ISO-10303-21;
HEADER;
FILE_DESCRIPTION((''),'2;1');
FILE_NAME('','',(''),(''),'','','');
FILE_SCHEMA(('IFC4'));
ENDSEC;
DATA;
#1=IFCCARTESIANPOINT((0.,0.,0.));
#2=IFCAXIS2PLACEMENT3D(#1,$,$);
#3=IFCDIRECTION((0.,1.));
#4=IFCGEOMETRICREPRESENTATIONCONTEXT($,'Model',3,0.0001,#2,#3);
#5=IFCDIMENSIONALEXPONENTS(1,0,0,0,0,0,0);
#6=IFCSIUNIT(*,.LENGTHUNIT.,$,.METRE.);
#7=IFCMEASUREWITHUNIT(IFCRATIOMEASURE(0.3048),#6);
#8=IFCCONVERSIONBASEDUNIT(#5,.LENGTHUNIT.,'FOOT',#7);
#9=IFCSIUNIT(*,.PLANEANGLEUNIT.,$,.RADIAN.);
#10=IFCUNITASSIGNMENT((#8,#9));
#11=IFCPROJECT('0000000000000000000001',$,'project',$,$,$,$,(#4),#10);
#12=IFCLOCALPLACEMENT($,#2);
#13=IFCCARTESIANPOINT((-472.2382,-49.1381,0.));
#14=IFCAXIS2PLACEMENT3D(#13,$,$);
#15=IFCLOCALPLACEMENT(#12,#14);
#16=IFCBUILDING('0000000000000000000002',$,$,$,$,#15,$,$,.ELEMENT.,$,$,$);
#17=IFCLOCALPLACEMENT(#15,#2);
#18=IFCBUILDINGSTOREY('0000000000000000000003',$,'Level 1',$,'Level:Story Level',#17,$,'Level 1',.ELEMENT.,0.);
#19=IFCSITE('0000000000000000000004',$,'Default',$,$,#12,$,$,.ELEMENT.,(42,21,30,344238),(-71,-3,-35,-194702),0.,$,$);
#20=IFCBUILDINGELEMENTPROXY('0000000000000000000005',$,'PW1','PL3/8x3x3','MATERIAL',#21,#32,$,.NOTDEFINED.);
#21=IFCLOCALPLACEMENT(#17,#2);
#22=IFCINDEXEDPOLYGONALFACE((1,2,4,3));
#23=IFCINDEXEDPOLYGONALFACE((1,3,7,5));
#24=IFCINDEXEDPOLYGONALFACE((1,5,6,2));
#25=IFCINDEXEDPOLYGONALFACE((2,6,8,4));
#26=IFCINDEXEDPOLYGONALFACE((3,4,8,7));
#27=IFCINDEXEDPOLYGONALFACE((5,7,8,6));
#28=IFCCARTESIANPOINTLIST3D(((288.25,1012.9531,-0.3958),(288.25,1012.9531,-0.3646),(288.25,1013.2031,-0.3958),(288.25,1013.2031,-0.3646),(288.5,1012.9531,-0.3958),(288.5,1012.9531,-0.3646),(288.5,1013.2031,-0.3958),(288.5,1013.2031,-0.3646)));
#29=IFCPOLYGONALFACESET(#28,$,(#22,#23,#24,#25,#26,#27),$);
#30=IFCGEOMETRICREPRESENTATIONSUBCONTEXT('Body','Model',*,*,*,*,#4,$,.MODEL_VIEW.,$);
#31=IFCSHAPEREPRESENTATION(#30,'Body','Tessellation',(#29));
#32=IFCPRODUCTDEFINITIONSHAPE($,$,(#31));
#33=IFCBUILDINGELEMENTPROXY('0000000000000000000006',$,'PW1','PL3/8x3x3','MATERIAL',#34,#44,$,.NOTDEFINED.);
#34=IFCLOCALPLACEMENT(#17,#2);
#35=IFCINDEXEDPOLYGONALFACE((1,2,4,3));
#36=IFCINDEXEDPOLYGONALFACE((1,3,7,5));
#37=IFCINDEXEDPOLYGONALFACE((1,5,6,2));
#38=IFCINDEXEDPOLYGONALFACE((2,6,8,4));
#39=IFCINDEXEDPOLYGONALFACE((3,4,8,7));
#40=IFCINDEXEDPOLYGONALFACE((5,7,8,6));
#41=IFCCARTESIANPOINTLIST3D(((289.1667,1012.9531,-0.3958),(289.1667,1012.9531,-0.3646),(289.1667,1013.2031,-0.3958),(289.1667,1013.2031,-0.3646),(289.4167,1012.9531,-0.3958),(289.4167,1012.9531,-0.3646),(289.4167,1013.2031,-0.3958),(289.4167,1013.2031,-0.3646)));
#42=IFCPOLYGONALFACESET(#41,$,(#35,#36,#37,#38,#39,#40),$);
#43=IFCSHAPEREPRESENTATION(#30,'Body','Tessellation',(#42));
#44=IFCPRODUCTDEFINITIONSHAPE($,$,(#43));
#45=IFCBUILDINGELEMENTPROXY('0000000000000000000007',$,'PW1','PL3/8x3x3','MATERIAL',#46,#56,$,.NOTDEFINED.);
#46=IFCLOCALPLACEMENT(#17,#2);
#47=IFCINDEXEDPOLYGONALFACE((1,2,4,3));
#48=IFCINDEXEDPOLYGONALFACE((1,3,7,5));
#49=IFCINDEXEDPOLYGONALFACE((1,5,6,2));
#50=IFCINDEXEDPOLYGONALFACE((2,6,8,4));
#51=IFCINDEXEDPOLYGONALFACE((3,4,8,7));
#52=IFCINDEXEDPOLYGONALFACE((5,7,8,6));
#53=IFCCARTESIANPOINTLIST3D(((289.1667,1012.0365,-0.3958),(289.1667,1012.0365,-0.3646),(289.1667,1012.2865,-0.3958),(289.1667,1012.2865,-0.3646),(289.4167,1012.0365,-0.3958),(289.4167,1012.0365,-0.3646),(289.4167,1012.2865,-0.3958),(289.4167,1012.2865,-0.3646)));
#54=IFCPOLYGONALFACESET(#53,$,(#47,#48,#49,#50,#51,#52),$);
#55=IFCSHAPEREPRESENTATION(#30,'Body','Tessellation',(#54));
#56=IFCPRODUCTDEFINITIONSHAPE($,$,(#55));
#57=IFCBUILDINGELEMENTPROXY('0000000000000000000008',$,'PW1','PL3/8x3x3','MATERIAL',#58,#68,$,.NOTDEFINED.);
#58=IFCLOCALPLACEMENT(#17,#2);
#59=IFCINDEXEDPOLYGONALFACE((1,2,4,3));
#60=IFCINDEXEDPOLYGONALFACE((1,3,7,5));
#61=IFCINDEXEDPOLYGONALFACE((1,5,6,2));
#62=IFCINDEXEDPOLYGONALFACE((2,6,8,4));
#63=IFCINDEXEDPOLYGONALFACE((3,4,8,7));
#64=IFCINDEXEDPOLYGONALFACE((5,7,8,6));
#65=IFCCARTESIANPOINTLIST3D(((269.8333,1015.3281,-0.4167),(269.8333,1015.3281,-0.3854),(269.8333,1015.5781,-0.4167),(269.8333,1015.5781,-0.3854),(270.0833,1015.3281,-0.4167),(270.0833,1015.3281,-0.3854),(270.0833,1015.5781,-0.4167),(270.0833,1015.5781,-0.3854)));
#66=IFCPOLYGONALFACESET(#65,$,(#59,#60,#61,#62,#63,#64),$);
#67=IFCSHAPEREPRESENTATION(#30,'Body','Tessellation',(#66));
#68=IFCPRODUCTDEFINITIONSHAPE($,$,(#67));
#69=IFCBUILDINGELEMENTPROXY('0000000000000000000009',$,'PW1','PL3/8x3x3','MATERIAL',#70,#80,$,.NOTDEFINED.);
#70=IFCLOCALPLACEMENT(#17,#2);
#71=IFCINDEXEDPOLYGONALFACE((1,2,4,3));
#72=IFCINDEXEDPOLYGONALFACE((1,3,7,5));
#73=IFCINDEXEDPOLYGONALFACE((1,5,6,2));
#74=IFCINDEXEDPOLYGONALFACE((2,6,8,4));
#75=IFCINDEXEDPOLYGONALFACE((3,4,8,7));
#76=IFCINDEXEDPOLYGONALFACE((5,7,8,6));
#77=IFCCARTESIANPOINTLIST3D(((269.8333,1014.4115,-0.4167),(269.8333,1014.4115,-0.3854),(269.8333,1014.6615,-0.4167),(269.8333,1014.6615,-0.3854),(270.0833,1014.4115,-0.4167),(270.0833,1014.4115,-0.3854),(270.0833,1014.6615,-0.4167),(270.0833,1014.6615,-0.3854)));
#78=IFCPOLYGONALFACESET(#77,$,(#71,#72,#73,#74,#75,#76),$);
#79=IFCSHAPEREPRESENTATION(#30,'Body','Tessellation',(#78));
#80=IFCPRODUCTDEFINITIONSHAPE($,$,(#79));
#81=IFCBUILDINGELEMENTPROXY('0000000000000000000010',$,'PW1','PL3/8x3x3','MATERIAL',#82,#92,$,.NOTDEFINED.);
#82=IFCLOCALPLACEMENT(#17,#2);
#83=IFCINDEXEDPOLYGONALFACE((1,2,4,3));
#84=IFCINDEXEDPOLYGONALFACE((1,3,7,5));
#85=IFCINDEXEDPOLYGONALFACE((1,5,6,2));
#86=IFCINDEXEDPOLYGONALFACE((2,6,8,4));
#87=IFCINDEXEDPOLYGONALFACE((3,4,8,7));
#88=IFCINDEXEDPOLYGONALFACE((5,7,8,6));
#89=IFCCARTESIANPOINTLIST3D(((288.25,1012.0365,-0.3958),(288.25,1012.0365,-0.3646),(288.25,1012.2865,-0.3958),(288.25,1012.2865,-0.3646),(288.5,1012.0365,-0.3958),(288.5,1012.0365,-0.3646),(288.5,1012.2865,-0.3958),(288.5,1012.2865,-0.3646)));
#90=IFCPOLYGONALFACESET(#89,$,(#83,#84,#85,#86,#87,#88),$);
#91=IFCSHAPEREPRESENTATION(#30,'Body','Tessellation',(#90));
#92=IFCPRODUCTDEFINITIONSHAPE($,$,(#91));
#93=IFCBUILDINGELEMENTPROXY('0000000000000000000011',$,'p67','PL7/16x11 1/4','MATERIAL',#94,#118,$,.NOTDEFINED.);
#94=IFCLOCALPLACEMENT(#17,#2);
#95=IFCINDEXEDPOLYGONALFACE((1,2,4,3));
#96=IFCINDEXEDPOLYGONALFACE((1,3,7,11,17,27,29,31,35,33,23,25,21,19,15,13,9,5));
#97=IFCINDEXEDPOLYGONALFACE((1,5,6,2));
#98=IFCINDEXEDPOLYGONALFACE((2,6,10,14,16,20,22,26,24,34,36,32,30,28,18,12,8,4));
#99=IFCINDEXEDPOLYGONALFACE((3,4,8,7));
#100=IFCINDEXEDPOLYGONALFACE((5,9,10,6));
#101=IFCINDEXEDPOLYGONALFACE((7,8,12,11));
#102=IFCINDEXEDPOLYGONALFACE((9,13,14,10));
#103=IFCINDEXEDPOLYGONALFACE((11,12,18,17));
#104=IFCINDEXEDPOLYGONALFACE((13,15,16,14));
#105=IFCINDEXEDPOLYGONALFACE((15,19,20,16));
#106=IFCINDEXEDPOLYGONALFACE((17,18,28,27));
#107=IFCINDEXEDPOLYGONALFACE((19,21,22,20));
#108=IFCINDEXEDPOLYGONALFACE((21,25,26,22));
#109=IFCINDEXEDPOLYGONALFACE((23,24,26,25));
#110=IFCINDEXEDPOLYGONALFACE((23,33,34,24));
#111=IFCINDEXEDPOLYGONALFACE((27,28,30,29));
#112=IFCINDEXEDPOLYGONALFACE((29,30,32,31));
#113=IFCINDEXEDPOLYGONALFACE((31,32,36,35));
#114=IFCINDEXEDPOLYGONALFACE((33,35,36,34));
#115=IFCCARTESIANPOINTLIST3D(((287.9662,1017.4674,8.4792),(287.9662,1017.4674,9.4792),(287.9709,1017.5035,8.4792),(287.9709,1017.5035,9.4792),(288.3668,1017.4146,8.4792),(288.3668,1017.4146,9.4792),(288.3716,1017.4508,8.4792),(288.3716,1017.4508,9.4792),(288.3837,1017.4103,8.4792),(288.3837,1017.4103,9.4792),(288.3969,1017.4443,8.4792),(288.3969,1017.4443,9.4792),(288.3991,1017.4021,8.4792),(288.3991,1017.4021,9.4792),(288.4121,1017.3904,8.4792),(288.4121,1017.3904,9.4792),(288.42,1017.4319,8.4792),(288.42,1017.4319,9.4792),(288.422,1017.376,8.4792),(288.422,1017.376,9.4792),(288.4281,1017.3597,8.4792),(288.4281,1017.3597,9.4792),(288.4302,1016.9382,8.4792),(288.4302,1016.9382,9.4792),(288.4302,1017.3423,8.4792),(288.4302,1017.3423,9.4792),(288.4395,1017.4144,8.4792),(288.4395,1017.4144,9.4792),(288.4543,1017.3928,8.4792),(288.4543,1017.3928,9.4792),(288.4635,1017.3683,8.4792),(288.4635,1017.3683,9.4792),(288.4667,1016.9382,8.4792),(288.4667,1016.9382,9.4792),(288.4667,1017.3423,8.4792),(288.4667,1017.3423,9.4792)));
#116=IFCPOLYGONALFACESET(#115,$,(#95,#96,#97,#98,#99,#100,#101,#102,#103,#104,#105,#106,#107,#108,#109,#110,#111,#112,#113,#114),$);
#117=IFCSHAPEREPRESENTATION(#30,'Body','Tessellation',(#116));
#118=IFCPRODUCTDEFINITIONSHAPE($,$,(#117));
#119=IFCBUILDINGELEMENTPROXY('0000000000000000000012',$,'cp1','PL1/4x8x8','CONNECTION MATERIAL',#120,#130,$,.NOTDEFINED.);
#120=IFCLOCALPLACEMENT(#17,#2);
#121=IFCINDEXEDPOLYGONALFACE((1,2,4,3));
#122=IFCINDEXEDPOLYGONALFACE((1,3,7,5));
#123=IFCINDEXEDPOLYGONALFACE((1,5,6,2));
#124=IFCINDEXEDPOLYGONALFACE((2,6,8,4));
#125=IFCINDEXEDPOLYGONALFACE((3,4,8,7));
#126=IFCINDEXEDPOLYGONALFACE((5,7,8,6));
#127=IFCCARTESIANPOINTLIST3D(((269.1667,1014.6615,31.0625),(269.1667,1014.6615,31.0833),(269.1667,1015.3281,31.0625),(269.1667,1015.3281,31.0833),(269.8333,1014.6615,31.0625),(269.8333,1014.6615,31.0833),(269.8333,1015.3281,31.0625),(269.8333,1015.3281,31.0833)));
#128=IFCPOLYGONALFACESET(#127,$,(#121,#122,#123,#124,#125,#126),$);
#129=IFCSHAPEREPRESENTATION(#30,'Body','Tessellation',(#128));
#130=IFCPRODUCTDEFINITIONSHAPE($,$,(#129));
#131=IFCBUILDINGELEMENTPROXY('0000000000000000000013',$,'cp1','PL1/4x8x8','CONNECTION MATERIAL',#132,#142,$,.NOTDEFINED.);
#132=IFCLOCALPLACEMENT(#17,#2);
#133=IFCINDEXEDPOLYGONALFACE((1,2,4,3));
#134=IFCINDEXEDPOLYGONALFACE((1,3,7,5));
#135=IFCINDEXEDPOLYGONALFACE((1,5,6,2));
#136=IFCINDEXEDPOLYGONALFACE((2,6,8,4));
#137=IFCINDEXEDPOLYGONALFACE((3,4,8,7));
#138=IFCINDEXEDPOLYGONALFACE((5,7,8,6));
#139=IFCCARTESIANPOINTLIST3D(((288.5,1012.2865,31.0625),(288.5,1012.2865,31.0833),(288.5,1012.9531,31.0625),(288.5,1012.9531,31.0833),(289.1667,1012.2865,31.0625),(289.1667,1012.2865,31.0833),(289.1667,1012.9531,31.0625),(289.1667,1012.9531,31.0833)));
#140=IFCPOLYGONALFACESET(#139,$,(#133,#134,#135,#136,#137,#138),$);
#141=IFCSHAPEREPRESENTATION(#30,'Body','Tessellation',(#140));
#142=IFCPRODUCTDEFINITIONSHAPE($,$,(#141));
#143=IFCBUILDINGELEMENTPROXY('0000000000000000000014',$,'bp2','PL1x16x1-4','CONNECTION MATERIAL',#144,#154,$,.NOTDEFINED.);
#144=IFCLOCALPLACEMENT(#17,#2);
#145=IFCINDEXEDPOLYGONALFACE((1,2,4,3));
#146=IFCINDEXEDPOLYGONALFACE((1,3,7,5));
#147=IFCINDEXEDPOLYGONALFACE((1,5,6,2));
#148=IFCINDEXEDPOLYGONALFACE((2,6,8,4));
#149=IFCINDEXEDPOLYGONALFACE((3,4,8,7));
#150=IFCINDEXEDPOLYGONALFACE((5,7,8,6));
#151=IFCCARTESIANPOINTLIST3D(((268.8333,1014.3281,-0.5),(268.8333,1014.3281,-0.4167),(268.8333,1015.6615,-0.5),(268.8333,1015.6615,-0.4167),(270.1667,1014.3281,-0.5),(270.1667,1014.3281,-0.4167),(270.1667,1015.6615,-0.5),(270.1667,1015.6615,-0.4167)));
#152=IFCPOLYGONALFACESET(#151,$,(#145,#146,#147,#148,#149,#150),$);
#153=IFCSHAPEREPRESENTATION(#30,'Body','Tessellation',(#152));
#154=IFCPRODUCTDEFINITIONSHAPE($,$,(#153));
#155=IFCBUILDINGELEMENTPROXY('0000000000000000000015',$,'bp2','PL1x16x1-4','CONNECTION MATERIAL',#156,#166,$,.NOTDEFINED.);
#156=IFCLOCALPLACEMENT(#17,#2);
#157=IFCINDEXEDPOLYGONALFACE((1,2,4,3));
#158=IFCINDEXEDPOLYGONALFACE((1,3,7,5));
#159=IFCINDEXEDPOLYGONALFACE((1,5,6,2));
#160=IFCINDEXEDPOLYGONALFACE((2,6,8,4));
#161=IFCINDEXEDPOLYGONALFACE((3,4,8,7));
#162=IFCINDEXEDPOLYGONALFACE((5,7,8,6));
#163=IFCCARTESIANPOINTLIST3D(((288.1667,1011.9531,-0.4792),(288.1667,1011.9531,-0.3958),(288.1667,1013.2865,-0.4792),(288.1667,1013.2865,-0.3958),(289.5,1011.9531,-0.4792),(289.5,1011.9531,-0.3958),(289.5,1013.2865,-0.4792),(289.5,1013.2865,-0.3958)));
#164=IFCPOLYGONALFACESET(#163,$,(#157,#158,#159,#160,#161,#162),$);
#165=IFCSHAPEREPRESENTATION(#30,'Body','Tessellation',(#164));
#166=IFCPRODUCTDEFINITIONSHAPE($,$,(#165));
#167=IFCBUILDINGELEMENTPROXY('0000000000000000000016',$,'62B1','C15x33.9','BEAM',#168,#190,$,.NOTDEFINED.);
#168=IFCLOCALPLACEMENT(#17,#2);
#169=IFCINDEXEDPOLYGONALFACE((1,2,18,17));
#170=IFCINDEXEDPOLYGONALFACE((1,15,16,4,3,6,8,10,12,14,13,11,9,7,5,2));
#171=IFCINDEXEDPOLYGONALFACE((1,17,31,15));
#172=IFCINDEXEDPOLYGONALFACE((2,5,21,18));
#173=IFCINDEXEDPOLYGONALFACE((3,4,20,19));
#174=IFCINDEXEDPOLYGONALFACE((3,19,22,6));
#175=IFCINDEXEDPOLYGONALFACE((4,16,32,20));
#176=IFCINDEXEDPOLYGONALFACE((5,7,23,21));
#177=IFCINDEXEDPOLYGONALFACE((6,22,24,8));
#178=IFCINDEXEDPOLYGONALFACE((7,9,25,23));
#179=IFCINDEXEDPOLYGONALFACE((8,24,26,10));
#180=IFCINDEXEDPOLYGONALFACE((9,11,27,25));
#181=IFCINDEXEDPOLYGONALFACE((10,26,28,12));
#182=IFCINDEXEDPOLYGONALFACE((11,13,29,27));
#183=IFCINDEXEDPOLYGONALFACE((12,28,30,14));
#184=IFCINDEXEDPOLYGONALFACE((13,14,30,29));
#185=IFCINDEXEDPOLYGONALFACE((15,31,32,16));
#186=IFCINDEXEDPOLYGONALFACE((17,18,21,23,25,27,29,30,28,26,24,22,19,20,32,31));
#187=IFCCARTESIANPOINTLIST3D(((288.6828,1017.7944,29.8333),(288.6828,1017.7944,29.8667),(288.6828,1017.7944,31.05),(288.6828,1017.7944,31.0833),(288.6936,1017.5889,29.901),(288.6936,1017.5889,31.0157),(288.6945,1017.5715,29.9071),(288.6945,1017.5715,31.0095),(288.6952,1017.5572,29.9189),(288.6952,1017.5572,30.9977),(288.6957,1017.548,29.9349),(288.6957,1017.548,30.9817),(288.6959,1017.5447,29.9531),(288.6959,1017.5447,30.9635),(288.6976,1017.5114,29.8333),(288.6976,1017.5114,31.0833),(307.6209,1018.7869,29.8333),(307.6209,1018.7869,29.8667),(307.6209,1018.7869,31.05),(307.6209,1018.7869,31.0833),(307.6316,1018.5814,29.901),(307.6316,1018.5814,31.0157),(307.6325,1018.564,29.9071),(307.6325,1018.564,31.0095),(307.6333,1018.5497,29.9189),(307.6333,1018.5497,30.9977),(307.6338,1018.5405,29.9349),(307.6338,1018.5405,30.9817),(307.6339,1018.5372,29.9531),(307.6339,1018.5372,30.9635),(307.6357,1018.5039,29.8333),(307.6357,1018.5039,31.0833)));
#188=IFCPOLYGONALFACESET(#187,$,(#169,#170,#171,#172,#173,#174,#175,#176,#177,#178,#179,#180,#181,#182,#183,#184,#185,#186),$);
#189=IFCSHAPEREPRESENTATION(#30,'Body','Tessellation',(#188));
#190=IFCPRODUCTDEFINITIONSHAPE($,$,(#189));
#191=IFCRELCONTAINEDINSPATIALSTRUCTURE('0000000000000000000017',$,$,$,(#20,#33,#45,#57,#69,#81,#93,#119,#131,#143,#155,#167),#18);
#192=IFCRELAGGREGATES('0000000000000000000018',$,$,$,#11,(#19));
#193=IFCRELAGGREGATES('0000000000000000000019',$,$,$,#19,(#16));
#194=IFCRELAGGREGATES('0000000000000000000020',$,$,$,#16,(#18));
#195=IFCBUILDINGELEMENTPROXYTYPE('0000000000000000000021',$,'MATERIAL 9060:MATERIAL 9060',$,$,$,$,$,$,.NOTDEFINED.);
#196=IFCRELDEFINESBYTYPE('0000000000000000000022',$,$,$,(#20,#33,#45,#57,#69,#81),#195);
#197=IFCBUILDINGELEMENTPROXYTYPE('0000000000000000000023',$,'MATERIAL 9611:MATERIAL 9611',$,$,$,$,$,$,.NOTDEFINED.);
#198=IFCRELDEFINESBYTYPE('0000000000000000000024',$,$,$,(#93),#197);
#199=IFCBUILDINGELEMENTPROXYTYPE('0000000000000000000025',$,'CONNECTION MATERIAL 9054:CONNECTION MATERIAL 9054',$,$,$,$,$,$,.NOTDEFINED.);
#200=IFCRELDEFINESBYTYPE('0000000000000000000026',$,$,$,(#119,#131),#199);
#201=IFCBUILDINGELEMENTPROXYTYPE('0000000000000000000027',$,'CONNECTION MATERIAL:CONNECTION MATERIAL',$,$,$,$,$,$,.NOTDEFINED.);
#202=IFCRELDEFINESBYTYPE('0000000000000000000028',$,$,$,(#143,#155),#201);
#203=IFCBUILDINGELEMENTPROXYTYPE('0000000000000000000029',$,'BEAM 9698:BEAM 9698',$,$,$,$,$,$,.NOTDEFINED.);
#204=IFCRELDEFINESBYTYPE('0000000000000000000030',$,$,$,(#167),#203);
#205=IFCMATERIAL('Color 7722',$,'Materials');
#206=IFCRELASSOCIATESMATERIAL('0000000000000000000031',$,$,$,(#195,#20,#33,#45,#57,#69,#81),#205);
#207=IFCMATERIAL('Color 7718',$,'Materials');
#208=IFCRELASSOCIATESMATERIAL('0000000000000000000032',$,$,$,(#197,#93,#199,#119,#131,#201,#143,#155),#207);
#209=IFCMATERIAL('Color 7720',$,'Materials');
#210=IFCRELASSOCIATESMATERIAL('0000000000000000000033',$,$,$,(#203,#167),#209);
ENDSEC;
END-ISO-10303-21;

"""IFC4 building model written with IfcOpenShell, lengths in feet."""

from ifc_helpers import new_model, entity, si_unit, converted_unit, direction, frame, origin, origin_2d_with_axis, place, context, subcontext, project, spatial, polyline, rectangle, outline, extrude, source, transform, mapped, material, type_object, type_shapes, element, save


model = new_model("IFC4")

# Units and contexts
model_context = context("Model", 3, precision=0.0001, world=origin(), true_north=direction((0.0, 1.0)))
body_context = subcontext(model_context, "Body", "Model", "MODEL_VIEW")
ifc_project = project(units=[converted_unit("LENGTHUNIT", "FOOT", entity("IfcRatioMeasure", 0.3048), si_unit("LENGTHUNIT", "METRE"), dimensions=[1, 0, 0, 0, 0, 0, 0]), si_unit("PLANEANGLEUNIT", "RADIAN")], contexts=[model_context])

# Site, building, storey
site_placement = place(None, origin())
site = spatial("IfcSite", under=ifc_project, at=site_placement, Name="Default", CompositionType="ELEMENT", RefLatitude=(42, 21, 30, 344238), RefLongitude=(-71, -3, -35, -194702), RefElevation=0.0)
building_placement = place(site_placement, frame((-472.2382, -49.1381, 0.0)))
building = spatial("IfcBuilding", under=site, at=building_placement, CompositionType="ELEMENT")
storey_placement = place(building_placement, origin())
storey = spatial("IfcBuildingStorey", under=building, at=storey_placement, Name="Level 1", ObjectType="Level:Story Level", LongName="Level 1", CompositionType="ELEMENT", Elevation=0.0)

# Building element proxies
ifc_material_1 = material(Name="Color 7722", Category="Materials")
building_element_proxy_type_1 = type_object("IfcBuildingElementProxyType", Name="MATERIAL 9060:MATERIAL 9060", PredefinedType="NOTDEFINED", material=ifc_material_1)
shared_shape_1 = source(origin(), body_context, "Body", "SweptSolid", [
    extrude(rectangle(XDim=0.25, YDim=0.25, at=origin_2d_with_axis()), frame((0.125, -0.125, 0.0)), (0.0, 0.0, 1.0), 0.0312),
])
type_shapes(building_element_proxy_type_1, [shared_shape_1])
for number, where, z_axis, x_axis, name in (
    (1, (288.25, 1013.2031, -0.3646), (0.0, 0.0, -1.0), (0.0, -1.0, 0.0), "PW1"),
    (2, (289.1667, 1013.2031, -0.3646), (0.0, 0.0, -1.0), (0.0, -1.0, 0.0), "PW1"),
    (3, (289.1667, 1012.2865, -0.3646), (0.0, 0.0, -1.0), (0.0, -1.0, 0.0), "PW1"),
    (4, (269.8333, 1015.5781, -0.3854), (0.0, 0.0, -1.0), (0.0, -1.0, 0.0), "PW1"),
    (5, (269.8333, 1014.6615, -0.3854), (0.0, 0.0, -1.0), (0.0, -1.0, 0.0), "PW1"),
    (6, (288.25, 1012.2865, -0.3646), (0.0, 0.0, -1.0), (0.0, -1.0, 0.0), "PW1"),
):
    element("IfcBuildingElementProxy", number, at=place(building_placement, frame(where, z_axis=z_axis, x_axis=x_axis)), inside=storey, type_object=building_element_proxy_type_1, material=ifc_material_1, Name=name, Description="PL3/8x3x3", ObjectType="MATERIAL", PredefinedType="NOTDEFINED", context=body_context, shape_type="MappedRepresentation", body=[
        mapped(shared_shape_1, transform((0.0, 0.0, 0.0), scale=1.0)),
    ])
ifc_material_2 = material(Name="Color 7718", Category="Materials")
building_element_proxy_type_2 = type_object("IfcBuildingElementProxyType", Name="MATERIAL 9611:MATERIAL 9611", PredefinedType="NOTDEFINED", material=ifc_material_2)
shared_shape_2 = source(origin(), body_context, "Body", "SweptSolid", [
    extrude(outline(polyline([(0.0125, -0.0951), (0.4166, -0.0951), (0.4166, -0.0586), (0.0125, -0.0586), (-0.0048, -0.0565), (-0.0211, -0.0504), (-0.0355, -0.0405), (-0.0472, -0.0275), (-0.0554, -0.0121), (-0.0598, 0.0048), (-0.1125, 0.4054), (-0.1486, 0.4006), (-0.0959, 0.0), (-0.0894, -0.0253), (-0.0771, -0.0484), (-0.0596, -0.0679), (-0.038, -0.0827), (-0.0135, -0.0919), (0.0125, -0.0951)])), frame((0.0, -0.0834, -0.0951), z_axis=(1.0, 0.0, 0.0), x_axis=(0.0, -1.0, 0.0)), (0.0, 0.0, 1.0), 1.0),
])
type_shapes(building_element_proxy_type_2, [shared_shape_2])
proxy_1_placement = place(building_placement, frame((288.4667, 1017.4382, 9.4792), z_axis=(1.0, 0.0, 0.0), x_axis=(0.0, 0.0, -1.0)))
element("IfcBuildingElementProxy", 7, at=proxy_1_placement, inside=storey, type_object=building_element_proxy_type_2, material=ifc_material_2, Name="p67", Description="PL7/16x11 1/4", ObjectType="MATERIAL", PredefinedType="NOTDEFINED", context=body_context, shape_type="MappedRepresentation", body=[
    mapped(shared_shape_2, transform((0.0, 0.0, 0.0), scale=1.0)),
])
building_element_proxy_type_3 = type_object("IfcBuildingElementProxyType", Name="CONNECTION MATERIAL 9054:CONNECTION MATERIAL 9054", PredefinedType="NOTDEFINED", material=ifc_material_2)
shared_shape_3 = source(origin(), body_context, "Body", "SweptSolid", [
    extrude(rectangle(XDim=0.6667, YDim=0.6667, at=origin_2d_with_axis()), frame((0.0, 0.0, -0.0208)), (0.0, 0.0, 1.0), 0.0208),
])
type_shapes(building_element_proxy_type_3, [shared_shape_3])
for number, where, z_axis, x_axis, name in (
    (8, (269.5, 1014.9948, 31.0625), (0.0, 0.0, -1.0), (1.0, 0.0, 0.0), "cp1"),
    (9, (288.8333, 1012.6198, 31.0625), (0.0, 0.0, -1.0), (1.0, 0.0, 0.0), "cp1"),
):
    element("IfcBuildingElementProxy", number, at=place(building_placement, frame(where, z_axis=z_axis, x_axis=x_axis)), inside=storey, type_object=building_element_proxy_type_3, material=ifc_material_2, Name=name, Description="PL1/4x8x8", ObjectType="CONNECTION MATERIAL", PredefinedType="NOTDEFINED", context=body_context, shape_type="MappedRepresentation", body=[
        mapped(shared_shape_3, transform((0.0, 0.0, 0.0), scale=1.0)),
    ])
building_element_proxy_type_4 = type_object("IfcBuildingElementProxyType", Name="CONNECTION MATERIAL:CONNECTION MATERIAL", PredefinedType="NOTDEFINED", material=ifc_material_2)
shared_shape_4 = source(origin(), body_context, "Body", "SweptSolid", [
    extrude(rectangle(XDim=1.3333, YDim=1.3333, at=origin_2d_with_axis()), frame((0.0, 0.0, -0.0833)), (0.0, 0.0, 1.0), 0.0833),
])
type_shapes(building_element_proxy_type_4, [shared_shape_4])
for number, where, name in (
    (10, (269.5, 1014.9948, -0.4167), "bp2"),
    (11, (288.8333, 1012.6198, -0.3958), "bp2"),
):
    element("IfcBuildingElementProxy", number, at=place(building_placement, frame(where)), inside=storey, type_object=building_element_proxy_type_4, material=ifc_material_2, Name=name, Description="PL1x16x1-4", ObjectType="CONNECTION MATERIAL", PredefinedType="NOTDEFINED", context=body_context, shape_type="MappedRepresentation", body=[
        mapped(shared_shape_4, transform((0.0, 0.0, 0.0), scale=1.0)),
    ])
ifc_material_3 = material(Name="Color 7720", Category="Materials")
building_element_proxy_type_5 = type_object("IfcBuildingElementProxyType", Name="BEAM 9698:BEAM 9698", PredefinedType="NOTDEFINED", material=ifc_material_3)
shared_shape_5 = source(origin(), body_context, "Body", "SweptSolid", [
    extrude(outline(polyline([(-0.625, -0.1025), (0.625, -0.1025), (0.625, 0.1808), (0.5917, 0.1808), (0.5574, -0.025), (0.5512, -0.0424), (0.5394, -0.0566), (0.5234, -0.0659), (0.5052, -0.0692), (-0.5052, -0.0692), (-0.5234, -0.0659), (-0.5394, -0.0566), (-0.5512, -0.0424), (-0.5574, -0.025), (-0.5917, 0.1808), (-0.625, 0.1808), (-0.625, -0.1025)])), frame((0.0, 0.625, 0.1808), z_axis=(1.0, 0.0, 0.0), x_axis=(0.0, -1.0, 0.0)), (0.0, 0.0, 1.0), 18.964),
])
type_shapes(building_element_proxy_type_5, [shared_shape_5])
proxy_2_placement = place(building_placement, frame((288.6828, 1017.7944, 29.8333), z_axis=(0.052336, -0.99863, 0.0), x_axis=(0.99863, 0.052336, 0.0)))
element("IfcBuildingElementProxy", 12, at=proxy_2_placement, inside=storey, type_object=building_element_proxy_type_5, material=ifc_material_3, Name="62B1", Description="C15x33.9", ObjectType="BEAM", PredefinedType="NOTDEFINED", context=body_context, shape_type="MappedRepresentation", body=[
    mapped(shared_shape_5, transform((0.0, 0.0, 0.0), scale=1.0)),
])

save(model, "model.ifc")
